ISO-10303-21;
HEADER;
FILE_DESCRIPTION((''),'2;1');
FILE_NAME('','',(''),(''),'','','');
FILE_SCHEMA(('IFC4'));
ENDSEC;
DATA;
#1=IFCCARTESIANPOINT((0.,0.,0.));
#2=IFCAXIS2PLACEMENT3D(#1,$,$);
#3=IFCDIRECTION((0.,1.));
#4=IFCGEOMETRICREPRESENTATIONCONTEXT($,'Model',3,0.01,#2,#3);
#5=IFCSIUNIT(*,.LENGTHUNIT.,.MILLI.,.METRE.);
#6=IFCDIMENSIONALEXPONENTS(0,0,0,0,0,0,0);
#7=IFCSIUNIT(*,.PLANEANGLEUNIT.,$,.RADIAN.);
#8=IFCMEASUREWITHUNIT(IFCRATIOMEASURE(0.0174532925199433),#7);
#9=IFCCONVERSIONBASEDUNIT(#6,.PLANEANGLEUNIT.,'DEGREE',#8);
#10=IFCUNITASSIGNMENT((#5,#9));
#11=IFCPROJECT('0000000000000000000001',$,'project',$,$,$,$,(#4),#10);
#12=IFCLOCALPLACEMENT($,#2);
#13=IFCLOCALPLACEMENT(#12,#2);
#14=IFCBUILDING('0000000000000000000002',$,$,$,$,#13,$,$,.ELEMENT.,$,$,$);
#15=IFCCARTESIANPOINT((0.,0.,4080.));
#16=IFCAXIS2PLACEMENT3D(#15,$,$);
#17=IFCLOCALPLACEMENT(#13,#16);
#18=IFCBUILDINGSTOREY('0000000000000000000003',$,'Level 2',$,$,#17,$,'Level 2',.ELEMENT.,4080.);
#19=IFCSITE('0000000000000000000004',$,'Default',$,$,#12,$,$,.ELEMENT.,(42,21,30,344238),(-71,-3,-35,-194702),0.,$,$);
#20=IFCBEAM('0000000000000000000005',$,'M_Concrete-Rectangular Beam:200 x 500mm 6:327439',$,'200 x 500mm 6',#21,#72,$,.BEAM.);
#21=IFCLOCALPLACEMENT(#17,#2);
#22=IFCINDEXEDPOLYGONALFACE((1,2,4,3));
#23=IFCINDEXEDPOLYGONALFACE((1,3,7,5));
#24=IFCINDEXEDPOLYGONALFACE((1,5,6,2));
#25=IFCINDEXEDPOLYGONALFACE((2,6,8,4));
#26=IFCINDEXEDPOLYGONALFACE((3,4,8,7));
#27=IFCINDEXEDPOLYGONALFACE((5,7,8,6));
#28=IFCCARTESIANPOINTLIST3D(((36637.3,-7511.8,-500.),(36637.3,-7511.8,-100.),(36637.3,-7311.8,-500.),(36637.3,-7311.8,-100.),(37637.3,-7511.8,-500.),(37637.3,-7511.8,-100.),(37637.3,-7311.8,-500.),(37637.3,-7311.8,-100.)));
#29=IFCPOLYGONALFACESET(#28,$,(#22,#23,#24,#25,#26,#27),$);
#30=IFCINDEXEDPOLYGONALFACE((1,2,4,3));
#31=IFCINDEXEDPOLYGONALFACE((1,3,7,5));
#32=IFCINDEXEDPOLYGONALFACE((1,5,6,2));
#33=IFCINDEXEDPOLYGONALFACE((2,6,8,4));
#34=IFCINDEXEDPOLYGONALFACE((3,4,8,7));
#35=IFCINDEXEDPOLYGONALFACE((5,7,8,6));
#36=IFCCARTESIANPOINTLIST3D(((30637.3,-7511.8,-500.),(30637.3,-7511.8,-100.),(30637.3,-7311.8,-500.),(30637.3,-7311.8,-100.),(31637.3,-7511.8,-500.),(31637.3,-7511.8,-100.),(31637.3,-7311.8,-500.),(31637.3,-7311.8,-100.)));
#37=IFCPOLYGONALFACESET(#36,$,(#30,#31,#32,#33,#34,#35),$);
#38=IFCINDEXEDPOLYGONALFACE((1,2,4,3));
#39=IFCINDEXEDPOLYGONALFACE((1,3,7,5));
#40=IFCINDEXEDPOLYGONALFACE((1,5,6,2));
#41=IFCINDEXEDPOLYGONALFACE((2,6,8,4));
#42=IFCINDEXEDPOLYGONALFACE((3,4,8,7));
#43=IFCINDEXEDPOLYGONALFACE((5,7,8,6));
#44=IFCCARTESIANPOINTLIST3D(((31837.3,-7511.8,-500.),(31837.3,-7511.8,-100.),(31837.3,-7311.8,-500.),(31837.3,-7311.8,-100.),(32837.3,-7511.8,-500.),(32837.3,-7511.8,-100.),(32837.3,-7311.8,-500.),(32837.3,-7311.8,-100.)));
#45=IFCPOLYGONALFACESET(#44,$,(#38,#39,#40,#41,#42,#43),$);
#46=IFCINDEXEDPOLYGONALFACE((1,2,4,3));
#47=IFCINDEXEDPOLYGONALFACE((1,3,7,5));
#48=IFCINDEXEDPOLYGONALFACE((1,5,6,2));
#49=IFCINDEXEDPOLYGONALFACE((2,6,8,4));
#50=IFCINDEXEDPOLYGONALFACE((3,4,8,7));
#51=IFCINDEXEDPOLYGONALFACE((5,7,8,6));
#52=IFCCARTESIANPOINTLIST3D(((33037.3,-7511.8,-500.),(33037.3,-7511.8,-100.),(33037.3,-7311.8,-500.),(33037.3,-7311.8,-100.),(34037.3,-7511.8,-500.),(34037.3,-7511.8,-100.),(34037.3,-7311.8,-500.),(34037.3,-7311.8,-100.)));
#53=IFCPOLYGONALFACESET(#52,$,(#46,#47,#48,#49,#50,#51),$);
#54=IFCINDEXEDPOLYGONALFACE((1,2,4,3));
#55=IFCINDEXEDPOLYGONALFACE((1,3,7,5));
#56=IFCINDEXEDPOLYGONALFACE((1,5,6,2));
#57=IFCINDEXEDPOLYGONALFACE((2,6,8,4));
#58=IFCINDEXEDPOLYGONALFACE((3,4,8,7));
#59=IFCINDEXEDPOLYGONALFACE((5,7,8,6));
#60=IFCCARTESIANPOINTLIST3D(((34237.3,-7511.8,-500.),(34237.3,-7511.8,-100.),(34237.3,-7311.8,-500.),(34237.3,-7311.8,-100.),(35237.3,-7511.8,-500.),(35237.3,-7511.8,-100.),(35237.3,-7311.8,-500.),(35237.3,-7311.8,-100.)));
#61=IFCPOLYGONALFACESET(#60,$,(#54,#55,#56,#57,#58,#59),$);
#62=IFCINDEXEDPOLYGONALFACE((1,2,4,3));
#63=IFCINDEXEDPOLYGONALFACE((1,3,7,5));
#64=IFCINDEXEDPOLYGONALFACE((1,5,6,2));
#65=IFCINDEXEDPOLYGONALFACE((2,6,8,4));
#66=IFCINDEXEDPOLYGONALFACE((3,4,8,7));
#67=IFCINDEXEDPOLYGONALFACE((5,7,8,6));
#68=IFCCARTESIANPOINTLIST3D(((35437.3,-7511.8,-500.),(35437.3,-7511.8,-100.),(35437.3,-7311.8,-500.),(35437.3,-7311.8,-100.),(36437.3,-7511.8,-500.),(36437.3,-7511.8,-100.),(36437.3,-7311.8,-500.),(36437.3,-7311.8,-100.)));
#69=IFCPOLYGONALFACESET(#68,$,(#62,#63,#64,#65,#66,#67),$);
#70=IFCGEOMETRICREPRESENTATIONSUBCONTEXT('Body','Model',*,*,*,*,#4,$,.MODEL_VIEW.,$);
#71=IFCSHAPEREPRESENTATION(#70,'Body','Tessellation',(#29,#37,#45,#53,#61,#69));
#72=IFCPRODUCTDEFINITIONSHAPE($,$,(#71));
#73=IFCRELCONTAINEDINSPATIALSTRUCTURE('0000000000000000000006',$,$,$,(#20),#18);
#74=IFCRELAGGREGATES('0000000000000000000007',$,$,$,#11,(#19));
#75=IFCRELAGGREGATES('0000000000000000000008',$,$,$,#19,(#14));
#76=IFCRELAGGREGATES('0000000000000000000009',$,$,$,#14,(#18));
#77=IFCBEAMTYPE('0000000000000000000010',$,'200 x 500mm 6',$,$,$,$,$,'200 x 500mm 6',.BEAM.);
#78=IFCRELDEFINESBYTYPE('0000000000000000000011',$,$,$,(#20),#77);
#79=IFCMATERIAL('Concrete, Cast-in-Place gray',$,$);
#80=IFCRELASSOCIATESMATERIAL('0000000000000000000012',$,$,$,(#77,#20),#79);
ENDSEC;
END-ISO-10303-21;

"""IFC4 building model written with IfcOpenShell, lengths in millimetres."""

from ifc_helpers import new_model, entity, si_unit, converted_unit, direction, frame, frame_2d, origin, origin_2d_with_axis, place, context, subcontext, project, spatial, rectangle, extrude, source, transform, mapped, material, type_object, type_shapes, element, save


model = new_model("IFC4")

# Units and contexts
model_context = context("Model", 3, precision=0.01, world=origin(), true_north=direction((0.0, 1.0)))
body_context = subcontext(model_context, "Body", "Model", "MODEL_VIEW")
ifc_project = project(units=[si_unit("LENGTHUNIT", "METRE", prefix="MILLI"), converted_unit("PLANEANGLEUNIT", "DEGREE", entity("IfcRatioMeasure", 0.0174532925199433), si_unit("PLANEANGLEUNIT", "RADIAN"), dimensions=[0, 0, 0, 0, 0, 0, 0])], contexts=[model_context])

# Site, building, storey
site_placement = place(None, origin())
site = spatial("IfcSite", under=ifc_project, at=site_placement, Name="Default", CompositionType="ELEMENT", RefLatitude=(42, 21, 30, 344238), RefLongitude=(-71, -3, -35, -194702), RefElevation=0.0)
building_placement = place(site_placement, origin())
building = spatial("IfcBuilding", under=site, at=building_placement, CompositionType="ELEMENT")
storey_placement = place(building_placement, frame((0.0, 0.0, 4080.0)))
storey = spatial("IfcBuildingStorey", under=building, at=storey_placement, Name="Level 2", LongName="Level 2", CompositionType="ELEMENT", Elevation=4080.0)

# Beam
ifc_material = material(Name="Concrete, Cast-in-Place gray")
beam_type_1 = type_object("IfcBeamType", Name="200 x 500mm 6", ElementType="200 x 500mm 6", PredefinedType="BEAM", material=ifc_material)
shared_shape_1 = source(origin(), body_context, "Body", "SweptSolid", [
    extrude(rectangle(XDim=1000.0, YDim=200.0, at=frame_2d((0.0, 0.0), x_axis=(1.0, 0.0))), frame((37137.3, -7411.8, 3580.0), z_axis=(0.0, 0.0, 1.0), x_axis=(-1.0, 0.0, 0.0)), (0.0, 0.0, 1.0), 400.0),
    extrude(rectangle(XDim=1000.0, YDim=200.0, at=origin_2d_with_axis()), frame((31137.3, -7411.8, 3580.0)), (0.0, 0.0, 1.0), 400.0),
    extrude(rectangle(XDim=1000.0, YDim=200.0, at=frame_2d((0.0, 0.0), x_axis=(1.0, 0.0))), frame((32337.3, -7411.8, 3580.0)), (0.0, 0.0, 1.0), 400.0),
    extrude(rectangle(XDim=1000.0, YDim=200.0, at=origin_2d_with_axis()), frame((33537.3, -7411.8, 3580.0)), (0.0, 0.0, 1.0), 400.0),
    extrude(rectangle(XDim=1000.0, YDim=200.0, at=frame_2d((0.0, 0.0), x_axis=(1.0, 0.0))), frame((34737.3, -7411.8, 3580.0)), (0.0, 0.0, 1.0), 400.0),
    extrude(rectangle(XDim=1000.0, YDim=200.0, at=frame_2d((0.0, 0.0), x_axis=(1.0, 0.0))), frame((35937.3, -7411.8, 3580.0)), (0.0, 0.0, 1.0), 400.0),
])
type_shapes(beam_type_1, [shared_shape_1])
beam_1_placement = place(storey_placement, frame((0.0, 0.0, -4080.0)))
element("IfcBeam", 1, at=beam_1_placement, inside=storey, type_object=beam_type_1, material=ifc_material, Name="M_Concrete-Rectangular Beam:200 x 500mm 6:327439", ObjectType="200 x 500mm 6", PredefinedType="BEAM", context=body_context, shape_type="MappedRepresentation", body=[
    mapped(shared_shape_1, transform((0.0, 0.0, 0.0), scale=1.0)),
])

save(model, "model.ifc")
